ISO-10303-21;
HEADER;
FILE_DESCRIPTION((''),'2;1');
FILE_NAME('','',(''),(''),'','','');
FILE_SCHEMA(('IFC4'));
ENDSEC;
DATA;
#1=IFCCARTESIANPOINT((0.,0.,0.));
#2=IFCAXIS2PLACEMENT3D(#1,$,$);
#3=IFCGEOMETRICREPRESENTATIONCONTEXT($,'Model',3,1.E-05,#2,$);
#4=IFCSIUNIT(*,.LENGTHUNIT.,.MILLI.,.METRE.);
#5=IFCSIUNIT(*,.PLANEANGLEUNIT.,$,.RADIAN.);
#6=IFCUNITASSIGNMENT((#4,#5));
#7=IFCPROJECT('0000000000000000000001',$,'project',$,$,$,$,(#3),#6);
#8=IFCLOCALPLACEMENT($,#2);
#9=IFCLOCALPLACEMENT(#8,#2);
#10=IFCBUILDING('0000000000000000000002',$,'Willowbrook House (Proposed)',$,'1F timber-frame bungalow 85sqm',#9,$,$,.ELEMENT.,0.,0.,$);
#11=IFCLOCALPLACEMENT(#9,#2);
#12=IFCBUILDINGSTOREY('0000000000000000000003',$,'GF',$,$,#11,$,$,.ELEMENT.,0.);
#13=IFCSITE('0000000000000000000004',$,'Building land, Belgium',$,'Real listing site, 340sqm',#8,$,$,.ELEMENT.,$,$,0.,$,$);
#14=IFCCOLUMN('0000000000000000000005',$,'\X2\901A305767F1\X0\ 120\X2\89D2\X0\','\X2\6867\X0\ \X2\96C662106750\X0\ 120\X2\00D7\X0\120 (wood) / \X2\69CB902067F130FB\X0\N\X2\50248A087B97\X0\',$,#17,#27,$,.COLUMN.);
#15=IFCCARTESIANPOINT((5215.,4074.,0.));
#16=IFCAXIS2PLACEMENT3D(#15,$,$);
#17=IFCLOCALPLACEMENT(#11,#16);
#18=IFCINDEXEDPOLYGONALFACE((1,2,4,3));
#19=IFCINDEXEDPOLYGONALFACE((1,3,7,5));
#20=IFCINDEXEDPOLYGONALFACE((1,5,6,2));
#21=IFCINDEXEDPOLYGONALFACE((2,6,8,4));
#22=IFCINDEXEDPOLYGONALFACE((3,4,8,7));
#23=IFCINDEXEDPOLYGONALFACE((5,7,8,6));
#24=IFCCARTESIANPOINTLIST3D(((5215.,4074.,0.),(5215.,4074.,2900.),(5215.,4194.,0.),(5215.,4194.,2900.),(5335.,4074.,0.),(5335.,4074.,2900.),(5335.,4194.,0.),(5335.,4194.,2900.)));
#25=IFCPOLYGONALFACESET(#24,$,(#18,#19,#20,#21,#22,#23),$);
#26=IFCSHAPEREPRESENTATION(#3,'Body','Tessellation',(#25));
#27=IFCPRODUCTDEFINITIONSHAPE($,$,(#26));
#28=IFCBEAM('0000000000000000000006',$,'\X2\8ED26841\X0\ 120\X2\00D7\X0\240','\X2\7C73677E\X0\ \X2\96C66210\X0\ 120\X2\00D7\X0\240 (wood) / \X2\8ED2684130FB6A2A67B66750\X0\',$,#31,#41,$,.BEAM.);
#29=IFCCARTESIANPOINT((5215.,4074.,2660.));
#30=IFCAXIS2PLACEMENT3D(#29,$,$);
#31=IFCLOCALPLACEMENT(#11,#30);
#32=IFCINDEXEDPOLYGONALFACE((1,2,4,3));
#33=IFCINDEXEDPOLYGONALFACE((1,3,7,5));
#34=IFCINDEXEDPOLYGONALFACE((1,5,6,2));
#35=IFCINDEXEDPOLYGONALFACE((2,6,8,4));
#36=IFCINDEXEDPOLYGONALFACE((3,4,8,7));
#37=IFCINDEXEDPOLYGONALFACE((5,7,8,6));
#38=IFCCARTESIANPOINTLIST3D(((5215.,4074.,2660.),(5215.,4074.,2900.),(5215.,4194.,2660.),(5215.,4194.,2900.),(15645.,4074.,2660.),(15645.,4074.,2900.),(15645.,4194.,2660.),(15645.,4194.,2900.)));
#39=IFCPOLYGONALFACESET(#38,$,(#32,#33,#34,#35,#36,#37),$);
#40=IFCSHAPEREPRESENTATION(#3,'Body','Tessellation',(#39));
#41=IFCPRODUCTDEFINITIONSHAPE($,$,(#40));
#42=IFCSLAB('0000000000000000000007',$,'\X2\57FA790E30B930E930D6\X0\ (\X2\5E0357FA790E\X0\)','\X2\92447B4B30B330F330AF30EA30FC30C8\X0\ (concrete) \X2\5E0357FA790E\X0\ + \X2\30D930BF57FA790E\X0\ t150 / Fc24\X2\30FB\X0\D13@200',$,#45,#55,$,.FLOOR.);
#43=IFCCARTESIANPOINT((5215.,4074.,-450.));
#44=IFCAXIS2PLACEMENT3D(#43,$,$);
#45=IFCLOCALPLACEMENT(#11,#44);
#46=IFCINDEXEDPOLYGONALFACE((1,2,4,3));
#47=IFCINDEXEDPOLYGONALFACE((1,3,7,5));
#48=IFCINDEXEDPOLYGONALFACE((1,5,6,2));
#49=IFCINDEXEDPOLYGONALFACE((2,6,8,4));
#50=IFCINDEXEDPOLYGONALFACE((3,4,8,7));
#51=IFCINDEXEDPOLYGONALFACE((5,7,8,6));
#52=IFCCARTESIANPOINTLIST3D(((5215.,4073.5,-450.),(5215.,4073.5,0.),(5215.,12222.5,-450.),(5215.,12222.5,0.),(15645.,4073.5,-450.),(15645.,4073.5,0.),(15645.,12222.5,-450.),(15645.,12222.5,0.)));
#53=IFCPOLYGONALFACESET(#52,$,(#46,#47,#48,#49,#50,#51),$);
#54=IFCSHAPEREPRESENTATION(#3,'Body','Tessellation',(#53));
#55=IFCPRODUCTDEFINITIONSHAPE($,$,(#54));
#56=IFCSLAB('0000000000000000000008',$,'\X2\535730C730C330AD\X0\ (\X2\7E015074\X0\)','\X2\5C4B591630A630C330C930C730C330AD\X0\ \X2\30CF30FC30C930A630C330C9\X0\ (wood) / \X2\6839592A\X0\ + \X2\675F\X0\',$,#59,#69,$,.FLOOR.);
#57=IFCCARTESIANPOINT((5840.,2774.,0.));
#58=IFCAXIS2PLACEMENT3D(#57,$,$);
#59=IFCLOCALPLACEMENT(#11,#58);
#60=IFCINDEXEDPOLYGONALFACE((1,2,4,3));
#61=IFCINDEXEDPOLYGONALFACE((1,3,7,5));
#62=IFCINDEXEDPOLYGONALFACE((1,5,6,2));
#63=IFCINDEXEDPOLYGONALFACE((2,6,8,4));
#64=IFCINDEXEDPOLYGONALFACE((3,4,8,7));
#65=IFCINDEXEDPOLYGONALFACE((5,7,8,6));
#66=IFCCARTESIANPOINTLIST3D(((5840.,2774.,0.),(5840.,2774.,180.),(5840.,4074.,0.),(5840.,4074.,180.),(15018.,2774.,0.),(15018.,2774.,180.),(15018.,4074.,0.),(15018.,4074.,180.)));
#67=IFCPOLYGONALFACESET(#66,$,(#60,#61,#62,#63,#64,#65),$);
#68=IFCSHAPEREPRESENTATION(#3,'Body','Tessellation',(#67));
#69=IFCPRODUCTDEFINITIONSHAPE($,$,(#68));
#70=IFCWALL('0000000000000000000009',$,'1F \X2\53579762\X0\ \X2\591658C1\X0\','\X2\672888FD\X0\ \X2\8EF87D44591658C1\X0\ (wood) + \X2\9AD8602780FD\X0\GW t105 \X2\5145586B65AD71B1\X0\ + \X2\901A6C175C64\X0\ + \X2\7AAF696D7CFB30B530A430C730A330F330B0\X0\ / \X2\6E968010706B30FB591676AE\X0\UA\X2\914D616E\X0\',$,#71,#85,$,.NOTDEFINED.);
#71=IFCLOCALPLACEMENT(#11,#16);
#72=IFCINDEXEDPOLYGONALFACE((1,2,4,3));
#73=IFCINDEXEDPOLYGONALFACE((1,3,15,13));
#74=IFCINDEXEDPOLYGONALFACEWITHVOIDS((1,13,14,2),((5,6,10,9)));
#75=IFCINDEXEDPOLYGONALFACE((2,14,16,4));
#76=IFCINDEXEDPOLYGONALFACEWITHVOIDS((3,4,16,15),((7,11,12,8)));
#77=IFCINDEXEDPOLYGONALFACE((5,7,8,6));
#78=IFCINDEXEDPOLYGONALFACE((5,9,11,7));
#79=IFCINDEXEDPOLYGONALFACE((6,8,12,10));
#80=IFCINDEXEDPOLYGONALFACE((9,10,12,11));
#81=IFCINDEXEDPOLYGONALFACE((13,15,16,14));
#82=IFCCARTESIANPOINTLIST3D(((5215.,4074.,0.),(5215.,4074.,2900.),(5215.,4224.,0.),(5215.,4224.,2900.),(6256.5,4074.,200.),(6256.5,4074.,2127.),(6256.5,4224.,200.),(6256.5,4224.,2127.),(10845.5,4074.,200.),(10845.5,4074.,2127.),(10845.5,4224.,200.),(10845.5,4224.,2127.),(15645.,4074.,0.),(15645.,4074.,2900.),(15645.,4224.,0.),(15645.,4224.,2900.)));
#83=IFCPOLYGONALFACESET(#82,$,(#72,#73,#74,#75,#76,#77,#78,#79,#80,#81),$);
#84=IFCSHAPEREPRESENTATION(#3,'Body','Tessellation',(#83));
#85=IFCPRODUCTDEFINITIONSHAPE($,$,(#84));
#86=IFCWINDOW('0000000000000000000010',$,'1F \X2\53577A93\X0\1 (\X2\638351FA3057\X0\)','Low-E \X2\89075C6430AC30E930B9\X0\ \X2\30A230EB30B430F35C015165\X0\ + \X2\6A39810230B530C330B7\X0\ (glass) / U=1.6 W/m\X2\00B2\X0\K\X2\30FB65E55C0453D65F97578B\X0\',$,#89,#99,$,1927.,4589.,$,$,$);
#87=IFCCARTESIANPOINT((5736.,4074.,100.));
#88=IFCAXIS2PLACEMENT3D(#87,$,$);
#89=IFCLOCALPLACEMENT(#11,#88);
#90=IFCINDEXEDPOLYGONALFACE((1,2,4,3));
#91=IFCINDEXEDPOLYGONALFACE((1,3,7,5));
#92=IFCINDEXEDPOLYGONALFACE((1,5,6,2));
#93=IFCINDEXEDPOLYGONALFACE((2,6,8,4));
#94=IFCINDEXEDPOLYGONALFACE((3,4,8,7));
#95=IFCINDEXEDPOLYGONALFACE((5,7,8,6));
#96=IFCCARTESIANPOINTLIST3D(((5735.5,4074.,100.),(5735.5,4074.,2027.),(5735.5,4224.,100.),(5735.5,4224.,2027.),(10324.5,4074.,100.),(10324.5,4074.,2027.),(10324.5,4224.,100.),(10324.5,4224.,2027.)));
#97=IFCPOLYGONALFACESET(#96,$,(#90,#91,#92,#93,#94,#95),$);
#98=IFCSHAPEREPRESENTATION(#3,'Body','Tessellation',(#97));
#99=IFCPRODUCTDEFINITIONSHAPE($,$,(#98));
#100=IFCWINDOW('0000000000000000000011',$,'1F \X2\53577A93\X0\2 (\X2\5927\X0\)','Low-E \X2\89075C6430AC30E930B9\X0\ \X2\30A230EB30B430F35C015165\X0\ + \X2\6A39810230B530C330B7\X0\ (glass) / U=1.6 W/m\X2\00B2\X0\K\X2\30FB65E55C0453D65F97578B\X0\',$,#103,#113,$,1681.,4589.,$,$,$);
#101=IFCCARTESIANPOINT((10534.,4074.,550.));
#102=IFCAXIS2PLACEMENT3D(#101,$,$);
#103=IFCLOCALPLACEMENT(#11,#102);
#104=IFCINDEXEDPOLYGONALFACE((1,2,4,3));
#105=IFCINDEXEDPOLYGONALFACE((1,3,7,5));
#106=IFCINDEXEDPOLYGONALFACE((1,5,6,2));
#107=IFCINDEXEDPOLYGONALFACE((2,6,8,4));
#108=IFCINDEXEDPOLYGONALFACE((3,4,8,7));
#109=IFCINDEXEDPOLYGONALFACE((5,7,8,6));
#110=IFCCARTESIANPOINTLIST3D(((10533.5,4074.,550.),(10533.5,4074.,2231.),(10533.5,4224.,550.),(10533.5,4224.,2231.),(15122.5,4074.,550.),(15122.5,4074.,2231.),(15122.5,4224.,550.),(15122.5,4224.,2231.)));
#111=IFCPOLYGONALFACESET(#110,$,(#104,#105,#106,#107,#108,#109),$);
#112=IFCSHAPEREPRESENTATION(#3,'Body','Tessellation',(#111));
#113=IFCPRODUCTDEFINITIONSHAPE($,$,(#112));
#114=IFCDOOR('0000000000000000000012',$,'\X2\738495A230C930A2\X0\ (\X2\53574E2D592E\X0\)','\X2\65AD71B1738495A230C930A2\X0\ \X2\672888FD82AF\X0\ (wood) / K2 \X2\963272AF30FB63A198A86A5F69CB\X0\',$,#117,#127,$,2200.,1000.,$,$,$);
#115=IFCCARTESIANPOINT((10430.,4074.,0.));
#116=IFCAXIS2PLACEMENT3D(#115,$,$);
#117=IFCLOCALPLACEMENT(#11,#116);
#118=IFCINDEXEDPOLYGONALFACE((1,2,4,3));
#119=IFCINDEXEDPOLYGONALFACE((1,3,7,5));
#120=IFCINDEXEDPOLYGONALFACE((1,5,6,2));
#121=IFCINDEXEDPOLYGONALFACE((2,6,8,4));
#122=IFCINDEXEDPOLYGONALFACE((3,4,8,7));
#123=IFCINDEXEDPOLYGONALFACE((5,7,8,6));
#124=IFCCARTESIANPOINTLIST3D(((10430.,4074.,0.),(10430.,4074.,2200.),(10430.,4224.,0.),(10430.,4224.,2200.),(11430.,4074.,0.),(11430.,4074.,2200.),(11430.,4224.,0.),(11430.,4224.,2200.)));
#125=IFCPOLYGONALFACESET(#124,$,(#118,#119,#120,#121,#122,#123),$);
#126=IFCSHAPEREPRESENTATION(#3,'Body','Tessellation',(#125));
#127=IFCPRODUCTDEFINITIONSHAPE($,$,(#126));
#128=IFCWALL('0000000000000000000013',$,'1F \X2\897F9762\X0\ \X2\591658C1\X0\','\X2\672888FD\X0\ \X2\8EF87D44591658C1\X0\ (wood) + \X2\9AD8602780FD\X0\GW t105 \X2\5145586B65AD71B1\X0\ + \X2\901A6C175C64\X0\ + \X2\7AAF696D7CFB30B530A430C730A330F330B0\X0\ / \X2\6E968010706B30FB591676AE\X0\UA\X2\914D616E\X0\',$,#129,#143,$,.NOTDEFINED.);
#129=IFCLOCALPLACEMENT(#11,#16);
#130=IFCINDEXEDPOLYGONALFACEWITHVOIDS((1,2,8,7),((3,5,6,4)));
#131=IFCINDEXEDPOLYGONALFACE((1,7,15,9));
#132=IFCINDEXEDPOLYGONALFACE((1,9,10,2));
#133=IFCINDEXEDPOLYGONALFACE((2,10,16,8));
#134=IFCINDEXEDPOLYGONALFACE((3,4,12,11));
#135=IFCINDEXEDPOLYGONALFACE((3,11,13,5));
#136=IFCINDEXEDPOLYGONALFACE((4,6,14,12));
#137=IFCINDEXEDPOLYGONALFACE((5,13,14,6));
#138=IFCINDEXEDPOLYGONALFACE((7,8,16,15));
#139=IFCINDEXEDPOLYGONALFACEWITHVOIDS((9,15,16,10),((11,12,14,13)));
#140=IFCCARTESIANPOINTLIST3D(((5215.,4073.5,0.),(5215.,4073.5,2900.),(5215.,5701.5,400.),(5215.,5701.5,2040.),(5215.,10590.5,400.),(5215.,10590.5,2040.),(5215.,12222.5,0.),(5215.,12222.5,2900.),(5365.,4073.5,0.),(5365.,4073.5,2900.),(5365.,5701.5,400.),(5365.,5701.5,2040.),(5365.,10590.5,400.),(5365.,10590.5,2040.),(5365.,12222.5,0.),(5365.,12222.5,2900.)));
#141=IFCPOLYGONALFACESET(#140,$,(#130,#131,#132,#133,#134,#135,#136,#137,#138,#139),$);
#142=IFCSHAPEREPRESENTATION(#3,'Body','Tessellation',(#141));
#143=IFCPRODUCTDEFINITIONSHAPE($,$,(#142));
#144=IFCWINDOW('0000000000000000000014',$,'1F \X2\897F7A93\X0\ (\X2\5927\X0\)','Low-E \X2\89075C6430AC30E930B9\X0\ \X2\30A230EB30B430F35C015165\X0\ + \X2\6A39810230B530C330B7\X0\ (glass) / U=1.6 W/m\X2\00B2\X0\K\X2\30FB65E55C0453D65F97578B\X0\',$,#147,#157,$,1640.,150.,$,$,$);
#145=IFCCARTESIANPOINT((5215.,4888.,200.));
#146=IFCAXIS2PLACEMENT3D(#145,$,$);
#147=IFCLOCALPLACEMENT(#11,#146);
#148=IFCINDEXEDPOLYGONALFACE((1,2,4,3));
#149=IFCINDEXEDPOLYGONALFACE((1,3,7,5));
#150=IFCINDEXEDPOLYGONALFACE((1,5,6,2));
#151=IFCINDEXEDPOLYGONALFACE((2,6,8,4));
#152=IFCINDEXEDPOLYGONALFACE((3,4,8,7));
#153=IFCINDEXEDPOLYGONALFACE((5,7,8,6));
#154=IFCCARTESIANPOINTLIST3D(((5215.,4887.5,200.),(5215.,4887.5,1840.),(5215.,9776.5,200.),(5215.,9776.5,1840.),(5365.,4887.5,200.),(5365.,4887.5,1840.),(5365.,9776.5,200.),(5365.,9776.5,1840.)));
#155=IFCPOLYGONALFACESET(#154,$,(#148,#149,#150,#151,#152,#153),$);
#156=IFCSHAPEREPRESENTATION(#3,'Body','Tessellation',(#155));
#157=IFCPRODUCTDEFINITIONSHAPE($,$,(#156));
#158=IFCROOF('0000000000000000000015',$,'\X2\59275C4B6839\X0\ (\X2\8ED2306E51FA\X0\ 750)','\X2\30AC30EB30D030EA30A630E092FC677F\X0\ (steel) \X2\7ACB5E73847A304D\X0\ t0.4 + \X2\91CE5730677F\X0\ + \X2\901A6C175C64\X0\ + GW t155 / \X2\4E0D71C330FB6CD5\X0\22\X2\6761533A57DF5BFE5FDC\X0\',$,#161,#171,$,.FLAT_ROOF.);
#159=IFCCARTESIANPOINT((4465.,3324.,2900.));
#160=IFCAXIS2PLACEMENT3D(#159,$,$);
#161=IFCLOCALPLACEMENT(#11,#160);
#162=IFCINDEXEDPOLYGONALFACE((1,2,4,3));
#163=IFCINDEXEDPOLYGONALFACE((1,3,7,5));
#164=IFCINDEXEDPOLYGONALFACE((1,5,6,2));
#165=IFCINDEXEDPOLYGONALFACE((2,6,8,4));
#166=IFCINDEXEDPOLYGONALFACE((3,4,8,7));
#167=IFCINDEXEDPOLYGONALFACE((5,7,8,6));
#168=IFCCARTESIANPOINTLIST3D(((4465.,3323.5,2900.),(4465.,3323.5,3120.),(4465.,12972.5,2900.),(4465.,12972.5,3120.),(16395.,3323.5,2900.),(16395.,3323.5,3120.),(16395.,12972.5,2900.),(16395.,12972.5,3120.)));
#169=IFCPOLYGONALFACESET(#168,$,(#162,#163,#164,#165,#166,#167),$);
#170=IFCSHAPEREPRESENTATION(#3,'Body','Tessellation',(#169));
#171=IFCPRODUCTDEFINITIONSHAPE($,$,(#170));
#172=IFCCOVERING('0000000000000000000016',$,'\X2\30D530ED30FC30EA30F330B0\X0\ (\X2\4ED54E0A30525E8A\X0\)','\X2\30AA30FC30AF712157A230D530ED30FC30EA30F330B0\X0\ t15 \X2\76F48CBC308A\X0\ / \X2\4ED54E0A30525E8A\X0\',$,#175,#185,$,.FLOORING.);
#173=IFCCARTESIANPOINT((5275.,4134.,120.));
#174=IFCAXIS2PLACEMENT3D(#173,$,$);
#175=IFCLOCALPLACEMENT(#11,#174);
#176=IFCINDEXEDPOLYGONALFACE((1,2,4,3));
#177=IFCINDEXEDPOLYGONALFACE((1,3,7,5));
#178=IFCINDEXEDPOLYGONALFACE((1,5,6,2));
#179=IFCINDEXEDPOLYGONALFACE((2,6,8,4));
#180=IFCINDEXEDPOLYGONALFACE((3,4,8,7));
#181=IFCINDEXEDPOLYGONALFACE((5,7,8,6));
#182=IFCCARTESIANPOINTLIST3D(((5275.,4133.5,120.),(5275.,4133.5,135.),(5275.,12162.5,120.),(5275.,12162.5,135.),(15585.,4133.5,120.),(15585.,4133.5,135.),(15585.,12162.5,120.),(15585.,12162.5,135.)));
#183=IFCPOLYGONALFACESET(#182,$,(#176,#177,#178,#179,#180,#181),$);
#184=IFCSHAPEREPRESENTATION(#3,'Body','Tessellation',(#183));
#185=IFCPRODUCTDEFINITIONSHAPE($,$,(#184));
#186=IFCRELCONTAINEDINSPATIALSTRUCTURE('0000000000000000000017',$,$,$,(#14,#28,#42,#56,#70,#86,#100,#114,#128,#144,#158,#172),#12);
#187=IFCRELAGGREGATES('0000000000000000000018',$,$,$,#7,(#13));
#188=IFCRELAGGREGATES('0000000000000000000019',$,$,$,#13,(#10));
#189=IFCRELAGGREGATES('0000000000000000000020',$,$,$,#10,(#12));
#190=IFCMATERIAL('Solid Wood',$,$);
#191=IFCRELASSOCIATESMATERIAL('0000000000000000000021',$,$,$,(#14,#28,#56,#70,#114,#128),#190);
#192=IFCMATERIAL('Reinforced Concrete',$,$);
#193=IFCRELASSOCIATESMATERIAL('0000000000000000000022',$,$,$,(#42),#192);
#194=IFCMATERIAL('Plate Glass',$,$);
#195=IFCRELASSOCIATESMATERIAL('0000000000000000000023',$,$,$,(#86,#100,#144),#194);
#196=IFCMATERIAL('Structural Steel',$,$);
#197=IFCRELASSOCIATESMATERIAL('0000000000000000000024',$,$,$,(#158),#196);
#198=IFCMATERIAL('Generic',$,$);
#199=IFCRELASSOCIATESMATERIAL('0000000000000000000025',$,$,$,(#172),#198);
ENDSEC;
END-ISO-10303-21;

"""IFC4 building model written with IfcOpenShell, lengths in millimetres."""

from ifc_helpers import new_model, si_unit, frame, frame_2d, origin, place, context, project, spatial, rectangle, extrude, material, element, fill, save


model = new_model("IFC4")

# Units and contexts
model_context = context("Model", 3, precision=1e-05, world=origin())
ifc_project = project(units=[si_unit("LENGTHUNIT", "METRE", prefix="MILLI"), si_unit("PLANEANGLEUNIT", "RADIAN")], contexts=[model_context])

# Site, building, storey
site_placement = place(None, origin())
site = spatial("IfcSite", under=ifc_project, at=site_placement, Name="Building land, Belgium", ObjectType="Real listing site, 340sqm", CompositionType="ELEMENT", RefElevation=0.0)
building_placement = place(site_placement, origin())
building = spatial("IfcBuilding", under=site, at=building_placement, Name="Willowbrook House (Proposed)", ObjectType="1F timber-frame bungalow 85sqm", CompositionType="ELEMENT", ElevationOfRefHeight=0.0, ElevationOfTerrain=0.0)
storey_placement = place(building_placement, origin())
storey = spatial("IfcBuildingStorey", under=building, at=storey_placement, Name="GF", CompositionType="ELEMENT", Elevation=0.0)

# Column
ifc_material_1 = material(Name="Solid Wood")
column_placement = place(storey_placement, frame((5215.0, 4074.0, 0.0)))
element("IfcColumn", 1, at=column_placement, inside=storey, material=ifc_material_1, Name="通し柱 120角", Description="桧 集成材 120×120 (wood) / 構造柱・N値計算", PredefinedType="COLUMN", context=model_context, shape_type="SweptSolid", body=[
    extrude(rectangle(XDim=120.0, YDim=120.0, at=frame_2d((60.0, 60.0))), frame((5215.0, 4074.0, 0.0)), (0.0, 0.0, 1.0), 2900.0),
])

# Beam
beam_1_placement = place(storey_placement, frame((5215.0, 4074.0, 2660.0)))
element("IfcBeam", 2, at=beam_1_placement, inside=storey, material=ifc_material_1, Name="軒桁 120×240", Description="米松 集成 120×240 (wood) / 軒桁・横架材", PredefinedType="BEAM", context=model_context, shape_type="SweptSolid", body=[
    extrude(rectangle(XDim=10430.0, YDim=120.0, at=frame_2d((5215.0, 60.0))), frame((5215.0, 4074.0, 2660.0)), (0.0, 0.0, 1.0), 240.0),
])

# Slabs
ifc_material_2 = material(Name="Reinforced Concrete")
slab_1_placement = place(storey_placement, frame((5215.0, 4074.0, -450.0)))
element("IfcSlab", 3, at=slab_1_placement, inside=storey, material=ifc_material_2, Name="基礎スラブ (布基礎)", Description="鉄筋コンクリート (concrete) 布基礎 + ベタ基礎 t150 / Fc24・D13@200", PredefinedType="FLOOR", context=model_context, shape_type="SweptSolid", body=[
    extrude(rectangle(XDim=10430.0, YDim=8149.0, at=frame_2d((5215.0, 4074.0))), frame((5215.0, 4074.0, -450.0)), (0.0, 0.0, 1.0), 450.0),
])
slab_2_placement = place(storey_placement, frame((5840.0, 2774.0, 0.0)))
element("IfcSlab", 4, at=slab_2_placement, inside=storey, material=ifc_material_1, Name="南デッキ (縁側)", Description="屋外ウッドデッキ ハードウッド (wood) / 根太 + 束", PredefinedType="FLOOR", context=model_context, shape_type="SweptSolid", body=[
    extrude(rectangle(XDim=9178.0, YDim=1300.0, at=frame_2d((4589.0, 650.0))), frame((5840.0, 2774.0, 0.0)), (0.0, 0.0, 1.0), 180.0),
])

# Wall, openings, windows, door
wall_1_placement = place(storey_placement, frame((5215.0, 4074.0, 0.0)))
wall_1 = element("IfcWall", 5, at=wall_1_placement, inside=storey, material=ifc_material_1, Name="1F 南面 外壁", Description="木製 軸組外壁 (wood) + 高性能GW t105 充填断熱 + 通気層 + 窯業系サイディング / 準耐火・外皮UA配慮", PredefinedType="NOTDEFINED", context=model_context, shape_type="SweptSolid", body=[
    extrude(rectangle(XDim=10430.0, YDim=150.0, at=frame_2d((5215.0, 75.0))), frame((5215.0, 4074.0, 0.0)), (0.0, 0.0, 1.0), 2900.0),
])
opening_1_placement = place(storey_placement, frame((5736.0, 4074.0, 100.0)))
opening_1 = element("IfcOpeningElement", 6, at=opening_1_placement, cuts=wall_1, PredefinedType="NOTDEFINED", context=model_context, shape_type="SweptSolid", body=[
    extrude(rectangle(XDim=4589.0, YDim=150.0, at=frame_2d((2294.0, 75.0))), frame((5736.0, 4074.0, 100.0)), (0.0, 0.0, 1.0), 1927.0),
])
opening_2_placement = place(storey_placement, frame((10534.0, 4074.0, 550.0)))
opening_2 = element("IfcOpeningElement", 7, at=opening_2_placement, cuts=wall_1, PredefinedType="NOTDEFINED", context=model_context, shape_type="SweptSolid", body=[
    extrude(rectangle(XDim=4589.0, YDim=150.0, at=frame_2d((2294.0, 75.0))), frame((10534.0, 4074.0, 550.0)), (0.0, 0.0, 1.0), 1681.0),
])
opening_3_placement = place(storey_placement, frame((10430.0, 4074.0, 0.0)))
opening_3 = element("IfcOpeningElement", 8, at=opening_3_placement, cuts=wall_1, PredefinedType="NOTDEFINED", context=model_context, shape_type="SweptSolid", body=[
    extrude(rectangle(XDim=1000.0, YDim=150.0, at=frame_2d((500.0, 75.0))), frame((10430.0, 4074.0, 0.0)), (0.0, 0.0, 1.0), 2200.0),
])
ifc_material_3 = material(Name="Plate Glass")
window_1_placement = place(storey_placement, frame((5736.0, 4074.0, 100.0)))
window_1 = element("IfcWindow", 9, at=window_1_placement, inside=storey, material=ifc_material_3, Name="1F 南窓1 (掃出し)", Description="Low-E 複層ガラス アルゴン封入 + 樹脂サッシ (glass) / U=1.6 W/m²K・日射取得型", OverallHeight=1927.0, OverallWidth=4589.0, context=model_context, shape_type="SweptSolid", body=[
    extrude(rectangle(XDim=4589.0, YDim=150.0, at=frame_2d((2294.0, 75.0))), frame((5736.0, 4074.0, 100.0)), (0.0, 0.0, 1.0), 1927.0),
])
fill(opening_1, window_1)
window_2_placement = place(storey_placement, frame((10534.0, 4074.0, 550.0)))
window_2 = element("IfcWindow", 10, at=window_2_placement, inside=storey, material=ifc_material_3, Name="1F 南窓2 (大)", Description="Low-E 複層ガラス アルゴン封入 + 樹脂サッシ (glass) / U=1.6 W/m²K・日射取得型", OverallHeight=1681.0, OverallWidth=4589.0, context=model_context, shape_type="SweptSolid", body=[
    extrude(rectangle(XDim=4589.0, YDim=150.0, at=frame_2d((2294.0, 75.0))), frame((10534.0, 4074.0, 550.0)), (0.0, 0.0, 1.0), 1681.0),
])
fill(opening_2, window_2)
door_placement = place(storey_placement, frame((10430.0, 4074.0, 0.0)))
door = element("IfcDoor", 11, at=door_placement, inside=storey, material=ifc_material_1, Name="玄関ドア (南中央)", Description="断熱玄関ドア 木製芯 (wood) / K2 防犯・採風機構", OverallHeight=2200.0, OverallWidth=1000.0, context=model_context, shape_type="SweptSolid", body=[
    extrude(rectangle(XDim=1000.0, YDim=150.0, at=frame_2d((500.0, 75.0))), frame((10430.0, 4074.0, 0.0)), (0.0, 0.0, 1.0), 2200.0),
])
fill(opening_3, door)

# Wall, opening, window
wall_2_placement = place(storey_placement, frame((5215.0, 4074.0, 0.0)))
wall_2 = element("IfcWall", 12, at=wall_2_placement, inside=storey, material=ifc_material_1, Name="1F 西面 外壁", Description="木製 軸組外壁 (wood) + 高性能GW t105 充填断熱 + 通気層 + 窯業系サイディング / 準耐火・外皮UA配慮", PredefinedType="NOTDEFINED", context=model_context, shape_type="SweptSolid", body=[
    extrude(rectangle(XDim=150.0, YDim=8149.0, at=frame_2d((75.0, 4074.0))), frame((5215.0, 4074.0, 0.0)), (0.0, 0.0, 1.0), 2900.0),
])
opening_4_placement = place(storey_placement, frame((5215.0, 4888.0, 200.0)))
opening_4 = element("IfcOpeningElement", 13, at=opening_4_placement, cuts=wall_2, PredefinedType="NOTDEFINED", context=model_context, shape_type="SweptSolid", body=[
    extrude(rectangle(XDim=150.0, YDim=4889.0, at=frame_2d((75.0, 2444.0))), frame((5215.0, 4888.0, 200.0)), (0.0, 0.0, 1.0), 1640.0),
])
window_3_placement = place(storey_placement, frame((5215.0, 4888.0, 200.0)))
window_3 = element("IfcWindow", 14, at=window_3_placement, inside=storey, material=ifc_material_3, Name="1F 西窓 (大)", Description="Low-E 複層ガラス アルゴン封入 + 樹脂サッシ (glass) / U=1.6 W/m²K・日射取得型", OverallHeight=1640.0, OverallWidth=150.0, context=model_context, shape_type="SweptSolid", body=[
    extrude(rectangle(XDim=150.0, YDim=4889.0, at=frame_2d((75.0, 2444.0))), frame((5215.0, 4888.0, 200.0)), (0.0, 0.0, 1.0), 1640.0),
])
fill(opening_4, window_3)

# Roof
ifc_material_4 = material(Name="Structural Steel")
roof_placement = place(storey_placement, frame((4465.0, 3324.0, 2900.0)))
element("IfcRoof", 15, at=roof_placement, inside=storey, material=ifc_material_4, Name="大屋根 (軒の出 750)", Description="ガルバリウム鋼板 (steel) 立平葺き t0.4 + 野地板 + 通気層 + GW t155 / 不燃・法22条区域対応", PredefinedType="FLAT_ROOF", context=model_context, shape_type="SweptSolid", body=[
    extrude(rectangle(XDim=11930.0, YDim=9649.0, at=frame_2d((5965.0, 4824.0))), frame((4465.0, 3324.0, 2900.0)), (0.0, 0.0, 1.0), 220.0),
])

# Covering
ifc_material_5 = material(Name="Generic")
covering_1_placement = place(storey_placement, frame((5275.0, 4134.0, 120.0)))
element("IfcCovering", 16, at=covering_1_placement, inside=storey, material=ifc_material_5, Name="フローリング (仕上げ床)", Description="オーク無垢フローリング t15 直貼り / 仕上げ床", PredefinedType="FLOORING", context=model_context, shape_type="SweptSolid", body=[
    extrude(rectangle(XDim=10310.0, YDim=8029.0, at=frame_2d((5155.0, 4014.0))), frame((5275.0, 4134.0, 120.0)), (0.0, 0.0, 1.0), 15.0),
])

save(model, "model.ifc")
